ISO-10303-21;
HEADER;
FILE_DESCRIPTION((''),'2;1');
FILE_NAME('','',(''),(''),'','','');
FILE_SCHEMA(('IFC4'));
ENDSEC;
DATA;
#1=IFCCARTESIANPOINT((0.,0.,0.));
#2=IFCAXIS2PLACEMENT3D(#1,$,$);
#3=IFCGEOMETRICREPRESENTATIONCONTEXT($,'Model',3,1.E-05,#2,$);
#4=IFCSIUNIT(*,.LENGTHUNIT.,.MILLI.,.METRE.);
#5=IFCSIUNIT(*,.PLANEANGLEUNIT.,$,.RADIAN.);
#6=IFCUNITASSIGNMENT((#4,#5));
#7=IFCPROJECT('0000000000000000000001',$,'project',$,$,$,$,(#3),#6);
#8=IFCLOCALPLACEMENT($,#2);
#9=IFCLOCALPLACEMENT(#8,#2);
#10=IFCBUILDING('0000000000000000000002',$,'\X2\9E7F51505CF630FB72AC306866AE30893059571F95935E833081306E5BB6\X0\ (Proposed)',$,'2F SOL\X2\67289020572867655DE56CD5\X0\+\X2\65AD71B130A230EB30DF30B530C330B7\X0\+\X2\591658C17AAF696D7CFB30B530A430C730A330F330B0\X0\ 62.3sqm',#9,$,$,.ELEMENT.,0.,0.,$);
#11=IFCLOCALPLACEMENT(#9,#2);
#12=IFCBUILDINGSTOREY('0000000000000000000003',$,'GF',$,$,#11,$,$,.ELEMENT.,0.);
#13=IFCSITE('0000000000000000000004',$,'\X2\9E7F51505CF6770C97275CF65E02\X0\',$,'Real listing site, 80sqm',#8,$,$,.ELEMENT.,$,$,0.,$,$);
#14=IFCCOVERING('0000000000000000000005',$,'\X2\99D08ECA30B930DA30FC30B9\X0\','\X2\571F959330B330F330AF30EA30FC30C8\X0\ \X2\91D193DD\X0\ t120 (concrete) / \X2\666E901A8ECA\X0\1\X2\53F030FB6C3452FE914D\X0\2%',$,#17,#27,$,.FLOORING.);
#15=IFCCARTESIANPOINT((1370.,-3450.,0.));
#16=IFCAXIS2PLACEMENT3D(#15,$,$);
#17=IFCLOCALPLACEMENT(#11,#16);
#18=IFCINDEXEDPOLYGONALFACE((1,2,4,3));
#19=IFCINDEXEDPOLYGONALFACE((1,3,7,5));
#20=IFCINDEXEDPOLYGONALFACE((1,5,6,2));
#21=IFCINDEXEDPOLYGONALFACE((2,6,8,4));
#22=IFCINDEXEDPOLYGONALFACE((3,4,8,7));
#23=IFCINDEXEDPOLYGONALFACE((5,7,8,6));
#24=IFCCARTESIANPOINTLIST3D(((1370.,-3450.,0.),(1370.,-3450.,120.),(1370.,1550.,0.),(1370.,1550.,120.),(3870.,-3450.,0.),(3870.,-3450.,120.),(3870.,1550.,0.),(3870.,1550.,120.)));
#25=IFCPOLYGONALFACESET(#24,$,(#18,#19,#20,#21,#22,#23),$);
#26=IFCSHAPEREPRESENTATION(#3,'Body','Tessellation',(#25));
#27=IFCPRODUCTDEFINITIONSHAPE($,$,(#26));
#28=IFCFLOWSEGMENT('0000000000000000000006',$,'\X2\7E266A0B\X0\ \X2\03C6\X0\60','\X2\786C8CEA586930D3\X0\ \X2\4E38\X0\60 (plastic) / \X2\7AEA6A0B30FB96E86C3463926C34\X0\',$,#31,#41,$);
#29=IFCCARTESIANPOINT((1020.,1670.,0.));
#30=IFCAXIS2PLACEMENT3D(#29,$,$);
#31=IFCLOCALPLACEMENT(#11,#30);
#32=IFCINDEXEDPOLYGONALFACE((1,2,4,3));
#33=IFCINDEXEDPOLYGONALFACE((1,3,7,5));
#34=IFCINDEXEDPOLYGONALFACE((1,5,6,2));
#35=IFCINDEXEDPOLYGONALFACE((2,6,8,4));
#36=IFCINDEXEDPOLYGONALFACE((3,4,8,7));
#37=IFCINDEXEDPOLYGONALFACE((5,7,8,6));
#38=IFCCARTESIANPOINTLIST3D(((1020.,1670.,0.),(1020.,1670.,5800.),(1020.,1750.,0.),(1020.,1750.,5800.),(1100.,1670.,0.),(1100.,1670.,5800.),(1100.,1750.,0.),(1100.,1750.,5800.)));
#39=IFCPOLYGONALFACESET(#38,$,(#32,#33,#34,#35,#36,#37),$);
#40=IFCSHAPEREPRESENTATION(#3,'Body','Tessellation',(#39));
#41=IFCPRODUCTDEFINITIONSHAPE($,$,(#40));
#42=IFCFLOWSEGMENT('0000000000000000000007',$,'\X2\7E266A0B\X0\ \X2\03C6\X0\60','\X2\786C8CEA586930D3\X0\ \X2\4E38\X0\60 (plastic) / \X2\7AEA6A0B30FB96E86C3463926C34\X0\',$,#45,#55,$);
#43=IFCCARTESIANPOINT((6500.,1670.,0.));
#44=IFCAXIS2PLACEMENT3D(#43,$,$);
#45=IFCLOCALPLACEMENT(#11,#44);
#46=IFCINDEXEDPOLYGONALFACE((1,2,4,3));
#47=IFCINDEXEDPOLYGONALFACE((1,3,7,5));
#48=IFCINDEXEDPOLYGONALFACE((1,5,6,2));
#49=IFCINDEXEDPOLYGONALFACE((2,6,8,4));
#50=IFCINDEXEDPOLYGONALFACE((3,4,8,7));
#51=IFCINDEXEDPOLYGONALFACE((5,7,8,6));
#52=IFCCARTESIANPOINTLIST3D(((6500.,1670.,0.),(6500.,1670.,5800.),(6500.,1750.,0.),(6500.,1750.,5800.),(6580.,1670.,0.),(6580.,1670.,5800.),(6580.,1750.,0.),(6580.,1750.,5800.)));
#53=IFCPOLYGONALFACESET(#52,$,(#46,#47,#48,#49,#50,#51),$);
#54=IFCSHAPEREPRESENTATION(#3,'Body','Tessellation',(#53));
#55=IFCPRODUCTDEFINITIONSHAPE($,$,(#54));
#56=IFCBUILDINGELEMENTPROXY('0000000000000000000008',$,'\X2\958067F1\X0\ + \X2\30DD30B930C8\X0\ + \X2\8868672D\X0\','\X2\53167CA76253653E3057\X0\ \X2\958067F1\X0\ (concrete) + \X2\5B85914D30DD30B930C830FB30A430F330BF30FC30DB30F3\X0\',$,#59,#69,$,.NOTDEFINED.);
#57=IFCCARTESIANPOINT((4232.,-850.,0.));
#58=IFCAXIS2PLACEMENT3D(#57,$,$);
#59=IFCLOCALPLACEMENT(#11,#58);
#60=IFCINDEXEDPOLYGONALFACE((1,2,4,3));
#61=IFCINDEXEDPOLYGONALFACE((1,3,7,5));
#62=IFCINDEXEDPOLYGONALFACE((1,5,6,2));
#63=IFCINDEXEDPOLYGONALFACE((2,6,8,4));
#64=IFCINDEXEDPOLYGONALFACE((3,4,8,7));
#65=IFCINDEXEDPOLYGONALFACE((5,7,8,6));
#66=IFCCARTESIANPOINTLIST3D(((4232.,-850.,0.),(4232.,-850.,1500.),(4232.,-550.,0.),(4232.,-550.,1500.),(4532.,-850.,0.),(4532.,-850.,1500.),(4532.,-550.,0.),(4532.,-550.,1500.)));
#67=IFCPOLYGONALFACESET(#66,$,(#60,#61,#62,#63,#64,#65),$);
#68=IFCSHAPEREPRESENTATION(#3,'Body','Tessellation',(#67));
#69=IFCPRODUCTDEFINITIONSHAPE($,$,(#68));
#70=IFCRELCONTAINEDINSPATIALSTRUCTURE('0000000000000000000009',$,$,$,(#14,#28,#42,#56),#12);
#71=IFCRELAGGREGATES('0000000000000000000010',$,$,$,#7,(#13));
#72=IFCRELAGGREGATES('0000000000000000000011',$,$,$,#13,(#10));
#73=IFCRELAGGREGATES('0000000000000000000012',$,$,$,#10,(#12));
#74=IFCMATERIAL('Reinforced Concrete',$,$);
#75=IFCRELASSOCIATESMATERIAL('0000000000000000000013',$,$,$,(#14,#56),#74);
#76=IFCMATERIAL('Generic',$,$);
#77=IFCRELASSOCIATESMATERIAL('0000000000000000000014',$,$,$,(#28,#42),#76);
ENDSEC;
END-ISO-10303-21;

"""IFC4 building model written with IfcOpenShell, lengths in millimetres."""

from ifc_helpers import new_model, si_unit, frame, frame_2d, origin, place, context, project, spatial, rectangle, extrude, material, element, save


model = new_model("IFC4")

# Units and contexts
model_context = context("Model", 3, precision=1e-05, world=origin())
ifc_project = project(units=[si_unit("LENGTHUNIT", "METRE", prefix="MILLI"), si_unit("PLANEANGLEUNIT", "RADIAN")], contexts=[model_context])

# Site, building, storey
site_placement = place(None, origin())
site = spatial("IfcSite", under=ifc_project, at=site_placement, Name="鹿児島県霧島市", ObjectType="Real listing site, 80sqm", CompositionType="ELEMENT", RefElevation=0.0)
building_placement = place(site_placement, origin())
building = spatial("IfcBuilding", under=site, at=building_placement, Name="鹿児島・犬と暮らす土間広めの家 (Proposed)", ObjectType="2F SOL木造在来工法+断熱アルミサッシ+外壁窯業系サイディング 62.3sqm", CompositionType="ELEMENT", ElevationOfRefHeight=0.0, ElevationOfTerrain=0.0)
storey_placement = place(building_placement, origin())
storey = spatial("IfcBuildingStorey", under=building, at=storey_placement, Name="GF", CompositionType="ELEMENT", Elevation=0.0)

# Shared definitions
ifc_material_1 = material(Name="Reinforced Concrete")

# Covering
covering_1_placement = place(storey_placement, frame((1370.0, -3450.0, 0.0)))
element("IfcCovering", 1, at=covering_1_placement, inside=storey, material=ifc_material_1, Name="駐車スペース", Description="土間コンクリート 金鏝 t120 (concrete) / 普通車1台・水勾配2%", PredefinedType="FLOORING", context=model_context, shape_type="SweptSolid", body=[
    extrude(rectangle(XDim=2500.0, YDim=5000.0, at=frame_2d((1250.0, 2500.0))), frame((1370.0, -3450.0, 0.0)), (0.0, 0.0, 1.0), 120.0),
])

# Flow segments
ifc_material_2 = material(Name="Generic")
flow_segment_1_placement = place(storey_placement, frame((1020.0, 1670.0, 0.0)))
element("IfcFlowSegment", 2, at=flow_segment_1_placement, inside=storey, material=ifc_material_2, Name="縦樋 φ60", Description="硬質塩ビ 丸60 (plastic) / 竪樋・雨水排水", context=model_context, shape_type="SweptSolid", body=[
    extrude(rectangle(XDim=80.0, YDim=80.0, at=frame_2d((40.0, 40.0))), frame((1020.0, 1670.0, 0.0)), (0.0, 0.0, 1.0), 5800.0),
])
flow_segment_2_placement = place(storey_placement, frame((6500.0, 1670.0, 0.0)))
element("IfcFlowSegment", 3, at=flow_segment_2_placement, inside=storey, material=ifc_material_2, Name="縦樋 φ60", Description="硬質塩ビ 丸60 (plastic) / 竪樋・雨水排水", context=model_context, shape_type="SweptSolid", body=[
    extrude(rectangle(XDim=80.0, YDim=80.0, at=frame_2d((40.0, 40.0))), frame((6500.0, 1670.0, 0.0)), (0.0, 0.0, 1.0), 5800.0),
])

# Building element proxy
proxy_placement = place(storey_placement, frame((4232.0, -850.0, 0.0)))
element("IfcBuildingElementProxy", 4, at=proxy_placement, inside=storey, material=ifc_material_1, Name="門柱 + ポスト + 表札", Description="化粧打放し 門柱 (concrete) + 宅配ポスト・インターホン", PredefinedType="NOTDEFINED", context=model_context, shape_type="SweptSolid", body=[
    extrude(rectangle(XDim=300.0, YDim=300.0, at=frame_2d((150.0, 150.0))), frame((4232.0, -850.0, 0.0)), (0.0, 0.0, 1.0), 1500.0),
])

save(model, "model.ifc")
